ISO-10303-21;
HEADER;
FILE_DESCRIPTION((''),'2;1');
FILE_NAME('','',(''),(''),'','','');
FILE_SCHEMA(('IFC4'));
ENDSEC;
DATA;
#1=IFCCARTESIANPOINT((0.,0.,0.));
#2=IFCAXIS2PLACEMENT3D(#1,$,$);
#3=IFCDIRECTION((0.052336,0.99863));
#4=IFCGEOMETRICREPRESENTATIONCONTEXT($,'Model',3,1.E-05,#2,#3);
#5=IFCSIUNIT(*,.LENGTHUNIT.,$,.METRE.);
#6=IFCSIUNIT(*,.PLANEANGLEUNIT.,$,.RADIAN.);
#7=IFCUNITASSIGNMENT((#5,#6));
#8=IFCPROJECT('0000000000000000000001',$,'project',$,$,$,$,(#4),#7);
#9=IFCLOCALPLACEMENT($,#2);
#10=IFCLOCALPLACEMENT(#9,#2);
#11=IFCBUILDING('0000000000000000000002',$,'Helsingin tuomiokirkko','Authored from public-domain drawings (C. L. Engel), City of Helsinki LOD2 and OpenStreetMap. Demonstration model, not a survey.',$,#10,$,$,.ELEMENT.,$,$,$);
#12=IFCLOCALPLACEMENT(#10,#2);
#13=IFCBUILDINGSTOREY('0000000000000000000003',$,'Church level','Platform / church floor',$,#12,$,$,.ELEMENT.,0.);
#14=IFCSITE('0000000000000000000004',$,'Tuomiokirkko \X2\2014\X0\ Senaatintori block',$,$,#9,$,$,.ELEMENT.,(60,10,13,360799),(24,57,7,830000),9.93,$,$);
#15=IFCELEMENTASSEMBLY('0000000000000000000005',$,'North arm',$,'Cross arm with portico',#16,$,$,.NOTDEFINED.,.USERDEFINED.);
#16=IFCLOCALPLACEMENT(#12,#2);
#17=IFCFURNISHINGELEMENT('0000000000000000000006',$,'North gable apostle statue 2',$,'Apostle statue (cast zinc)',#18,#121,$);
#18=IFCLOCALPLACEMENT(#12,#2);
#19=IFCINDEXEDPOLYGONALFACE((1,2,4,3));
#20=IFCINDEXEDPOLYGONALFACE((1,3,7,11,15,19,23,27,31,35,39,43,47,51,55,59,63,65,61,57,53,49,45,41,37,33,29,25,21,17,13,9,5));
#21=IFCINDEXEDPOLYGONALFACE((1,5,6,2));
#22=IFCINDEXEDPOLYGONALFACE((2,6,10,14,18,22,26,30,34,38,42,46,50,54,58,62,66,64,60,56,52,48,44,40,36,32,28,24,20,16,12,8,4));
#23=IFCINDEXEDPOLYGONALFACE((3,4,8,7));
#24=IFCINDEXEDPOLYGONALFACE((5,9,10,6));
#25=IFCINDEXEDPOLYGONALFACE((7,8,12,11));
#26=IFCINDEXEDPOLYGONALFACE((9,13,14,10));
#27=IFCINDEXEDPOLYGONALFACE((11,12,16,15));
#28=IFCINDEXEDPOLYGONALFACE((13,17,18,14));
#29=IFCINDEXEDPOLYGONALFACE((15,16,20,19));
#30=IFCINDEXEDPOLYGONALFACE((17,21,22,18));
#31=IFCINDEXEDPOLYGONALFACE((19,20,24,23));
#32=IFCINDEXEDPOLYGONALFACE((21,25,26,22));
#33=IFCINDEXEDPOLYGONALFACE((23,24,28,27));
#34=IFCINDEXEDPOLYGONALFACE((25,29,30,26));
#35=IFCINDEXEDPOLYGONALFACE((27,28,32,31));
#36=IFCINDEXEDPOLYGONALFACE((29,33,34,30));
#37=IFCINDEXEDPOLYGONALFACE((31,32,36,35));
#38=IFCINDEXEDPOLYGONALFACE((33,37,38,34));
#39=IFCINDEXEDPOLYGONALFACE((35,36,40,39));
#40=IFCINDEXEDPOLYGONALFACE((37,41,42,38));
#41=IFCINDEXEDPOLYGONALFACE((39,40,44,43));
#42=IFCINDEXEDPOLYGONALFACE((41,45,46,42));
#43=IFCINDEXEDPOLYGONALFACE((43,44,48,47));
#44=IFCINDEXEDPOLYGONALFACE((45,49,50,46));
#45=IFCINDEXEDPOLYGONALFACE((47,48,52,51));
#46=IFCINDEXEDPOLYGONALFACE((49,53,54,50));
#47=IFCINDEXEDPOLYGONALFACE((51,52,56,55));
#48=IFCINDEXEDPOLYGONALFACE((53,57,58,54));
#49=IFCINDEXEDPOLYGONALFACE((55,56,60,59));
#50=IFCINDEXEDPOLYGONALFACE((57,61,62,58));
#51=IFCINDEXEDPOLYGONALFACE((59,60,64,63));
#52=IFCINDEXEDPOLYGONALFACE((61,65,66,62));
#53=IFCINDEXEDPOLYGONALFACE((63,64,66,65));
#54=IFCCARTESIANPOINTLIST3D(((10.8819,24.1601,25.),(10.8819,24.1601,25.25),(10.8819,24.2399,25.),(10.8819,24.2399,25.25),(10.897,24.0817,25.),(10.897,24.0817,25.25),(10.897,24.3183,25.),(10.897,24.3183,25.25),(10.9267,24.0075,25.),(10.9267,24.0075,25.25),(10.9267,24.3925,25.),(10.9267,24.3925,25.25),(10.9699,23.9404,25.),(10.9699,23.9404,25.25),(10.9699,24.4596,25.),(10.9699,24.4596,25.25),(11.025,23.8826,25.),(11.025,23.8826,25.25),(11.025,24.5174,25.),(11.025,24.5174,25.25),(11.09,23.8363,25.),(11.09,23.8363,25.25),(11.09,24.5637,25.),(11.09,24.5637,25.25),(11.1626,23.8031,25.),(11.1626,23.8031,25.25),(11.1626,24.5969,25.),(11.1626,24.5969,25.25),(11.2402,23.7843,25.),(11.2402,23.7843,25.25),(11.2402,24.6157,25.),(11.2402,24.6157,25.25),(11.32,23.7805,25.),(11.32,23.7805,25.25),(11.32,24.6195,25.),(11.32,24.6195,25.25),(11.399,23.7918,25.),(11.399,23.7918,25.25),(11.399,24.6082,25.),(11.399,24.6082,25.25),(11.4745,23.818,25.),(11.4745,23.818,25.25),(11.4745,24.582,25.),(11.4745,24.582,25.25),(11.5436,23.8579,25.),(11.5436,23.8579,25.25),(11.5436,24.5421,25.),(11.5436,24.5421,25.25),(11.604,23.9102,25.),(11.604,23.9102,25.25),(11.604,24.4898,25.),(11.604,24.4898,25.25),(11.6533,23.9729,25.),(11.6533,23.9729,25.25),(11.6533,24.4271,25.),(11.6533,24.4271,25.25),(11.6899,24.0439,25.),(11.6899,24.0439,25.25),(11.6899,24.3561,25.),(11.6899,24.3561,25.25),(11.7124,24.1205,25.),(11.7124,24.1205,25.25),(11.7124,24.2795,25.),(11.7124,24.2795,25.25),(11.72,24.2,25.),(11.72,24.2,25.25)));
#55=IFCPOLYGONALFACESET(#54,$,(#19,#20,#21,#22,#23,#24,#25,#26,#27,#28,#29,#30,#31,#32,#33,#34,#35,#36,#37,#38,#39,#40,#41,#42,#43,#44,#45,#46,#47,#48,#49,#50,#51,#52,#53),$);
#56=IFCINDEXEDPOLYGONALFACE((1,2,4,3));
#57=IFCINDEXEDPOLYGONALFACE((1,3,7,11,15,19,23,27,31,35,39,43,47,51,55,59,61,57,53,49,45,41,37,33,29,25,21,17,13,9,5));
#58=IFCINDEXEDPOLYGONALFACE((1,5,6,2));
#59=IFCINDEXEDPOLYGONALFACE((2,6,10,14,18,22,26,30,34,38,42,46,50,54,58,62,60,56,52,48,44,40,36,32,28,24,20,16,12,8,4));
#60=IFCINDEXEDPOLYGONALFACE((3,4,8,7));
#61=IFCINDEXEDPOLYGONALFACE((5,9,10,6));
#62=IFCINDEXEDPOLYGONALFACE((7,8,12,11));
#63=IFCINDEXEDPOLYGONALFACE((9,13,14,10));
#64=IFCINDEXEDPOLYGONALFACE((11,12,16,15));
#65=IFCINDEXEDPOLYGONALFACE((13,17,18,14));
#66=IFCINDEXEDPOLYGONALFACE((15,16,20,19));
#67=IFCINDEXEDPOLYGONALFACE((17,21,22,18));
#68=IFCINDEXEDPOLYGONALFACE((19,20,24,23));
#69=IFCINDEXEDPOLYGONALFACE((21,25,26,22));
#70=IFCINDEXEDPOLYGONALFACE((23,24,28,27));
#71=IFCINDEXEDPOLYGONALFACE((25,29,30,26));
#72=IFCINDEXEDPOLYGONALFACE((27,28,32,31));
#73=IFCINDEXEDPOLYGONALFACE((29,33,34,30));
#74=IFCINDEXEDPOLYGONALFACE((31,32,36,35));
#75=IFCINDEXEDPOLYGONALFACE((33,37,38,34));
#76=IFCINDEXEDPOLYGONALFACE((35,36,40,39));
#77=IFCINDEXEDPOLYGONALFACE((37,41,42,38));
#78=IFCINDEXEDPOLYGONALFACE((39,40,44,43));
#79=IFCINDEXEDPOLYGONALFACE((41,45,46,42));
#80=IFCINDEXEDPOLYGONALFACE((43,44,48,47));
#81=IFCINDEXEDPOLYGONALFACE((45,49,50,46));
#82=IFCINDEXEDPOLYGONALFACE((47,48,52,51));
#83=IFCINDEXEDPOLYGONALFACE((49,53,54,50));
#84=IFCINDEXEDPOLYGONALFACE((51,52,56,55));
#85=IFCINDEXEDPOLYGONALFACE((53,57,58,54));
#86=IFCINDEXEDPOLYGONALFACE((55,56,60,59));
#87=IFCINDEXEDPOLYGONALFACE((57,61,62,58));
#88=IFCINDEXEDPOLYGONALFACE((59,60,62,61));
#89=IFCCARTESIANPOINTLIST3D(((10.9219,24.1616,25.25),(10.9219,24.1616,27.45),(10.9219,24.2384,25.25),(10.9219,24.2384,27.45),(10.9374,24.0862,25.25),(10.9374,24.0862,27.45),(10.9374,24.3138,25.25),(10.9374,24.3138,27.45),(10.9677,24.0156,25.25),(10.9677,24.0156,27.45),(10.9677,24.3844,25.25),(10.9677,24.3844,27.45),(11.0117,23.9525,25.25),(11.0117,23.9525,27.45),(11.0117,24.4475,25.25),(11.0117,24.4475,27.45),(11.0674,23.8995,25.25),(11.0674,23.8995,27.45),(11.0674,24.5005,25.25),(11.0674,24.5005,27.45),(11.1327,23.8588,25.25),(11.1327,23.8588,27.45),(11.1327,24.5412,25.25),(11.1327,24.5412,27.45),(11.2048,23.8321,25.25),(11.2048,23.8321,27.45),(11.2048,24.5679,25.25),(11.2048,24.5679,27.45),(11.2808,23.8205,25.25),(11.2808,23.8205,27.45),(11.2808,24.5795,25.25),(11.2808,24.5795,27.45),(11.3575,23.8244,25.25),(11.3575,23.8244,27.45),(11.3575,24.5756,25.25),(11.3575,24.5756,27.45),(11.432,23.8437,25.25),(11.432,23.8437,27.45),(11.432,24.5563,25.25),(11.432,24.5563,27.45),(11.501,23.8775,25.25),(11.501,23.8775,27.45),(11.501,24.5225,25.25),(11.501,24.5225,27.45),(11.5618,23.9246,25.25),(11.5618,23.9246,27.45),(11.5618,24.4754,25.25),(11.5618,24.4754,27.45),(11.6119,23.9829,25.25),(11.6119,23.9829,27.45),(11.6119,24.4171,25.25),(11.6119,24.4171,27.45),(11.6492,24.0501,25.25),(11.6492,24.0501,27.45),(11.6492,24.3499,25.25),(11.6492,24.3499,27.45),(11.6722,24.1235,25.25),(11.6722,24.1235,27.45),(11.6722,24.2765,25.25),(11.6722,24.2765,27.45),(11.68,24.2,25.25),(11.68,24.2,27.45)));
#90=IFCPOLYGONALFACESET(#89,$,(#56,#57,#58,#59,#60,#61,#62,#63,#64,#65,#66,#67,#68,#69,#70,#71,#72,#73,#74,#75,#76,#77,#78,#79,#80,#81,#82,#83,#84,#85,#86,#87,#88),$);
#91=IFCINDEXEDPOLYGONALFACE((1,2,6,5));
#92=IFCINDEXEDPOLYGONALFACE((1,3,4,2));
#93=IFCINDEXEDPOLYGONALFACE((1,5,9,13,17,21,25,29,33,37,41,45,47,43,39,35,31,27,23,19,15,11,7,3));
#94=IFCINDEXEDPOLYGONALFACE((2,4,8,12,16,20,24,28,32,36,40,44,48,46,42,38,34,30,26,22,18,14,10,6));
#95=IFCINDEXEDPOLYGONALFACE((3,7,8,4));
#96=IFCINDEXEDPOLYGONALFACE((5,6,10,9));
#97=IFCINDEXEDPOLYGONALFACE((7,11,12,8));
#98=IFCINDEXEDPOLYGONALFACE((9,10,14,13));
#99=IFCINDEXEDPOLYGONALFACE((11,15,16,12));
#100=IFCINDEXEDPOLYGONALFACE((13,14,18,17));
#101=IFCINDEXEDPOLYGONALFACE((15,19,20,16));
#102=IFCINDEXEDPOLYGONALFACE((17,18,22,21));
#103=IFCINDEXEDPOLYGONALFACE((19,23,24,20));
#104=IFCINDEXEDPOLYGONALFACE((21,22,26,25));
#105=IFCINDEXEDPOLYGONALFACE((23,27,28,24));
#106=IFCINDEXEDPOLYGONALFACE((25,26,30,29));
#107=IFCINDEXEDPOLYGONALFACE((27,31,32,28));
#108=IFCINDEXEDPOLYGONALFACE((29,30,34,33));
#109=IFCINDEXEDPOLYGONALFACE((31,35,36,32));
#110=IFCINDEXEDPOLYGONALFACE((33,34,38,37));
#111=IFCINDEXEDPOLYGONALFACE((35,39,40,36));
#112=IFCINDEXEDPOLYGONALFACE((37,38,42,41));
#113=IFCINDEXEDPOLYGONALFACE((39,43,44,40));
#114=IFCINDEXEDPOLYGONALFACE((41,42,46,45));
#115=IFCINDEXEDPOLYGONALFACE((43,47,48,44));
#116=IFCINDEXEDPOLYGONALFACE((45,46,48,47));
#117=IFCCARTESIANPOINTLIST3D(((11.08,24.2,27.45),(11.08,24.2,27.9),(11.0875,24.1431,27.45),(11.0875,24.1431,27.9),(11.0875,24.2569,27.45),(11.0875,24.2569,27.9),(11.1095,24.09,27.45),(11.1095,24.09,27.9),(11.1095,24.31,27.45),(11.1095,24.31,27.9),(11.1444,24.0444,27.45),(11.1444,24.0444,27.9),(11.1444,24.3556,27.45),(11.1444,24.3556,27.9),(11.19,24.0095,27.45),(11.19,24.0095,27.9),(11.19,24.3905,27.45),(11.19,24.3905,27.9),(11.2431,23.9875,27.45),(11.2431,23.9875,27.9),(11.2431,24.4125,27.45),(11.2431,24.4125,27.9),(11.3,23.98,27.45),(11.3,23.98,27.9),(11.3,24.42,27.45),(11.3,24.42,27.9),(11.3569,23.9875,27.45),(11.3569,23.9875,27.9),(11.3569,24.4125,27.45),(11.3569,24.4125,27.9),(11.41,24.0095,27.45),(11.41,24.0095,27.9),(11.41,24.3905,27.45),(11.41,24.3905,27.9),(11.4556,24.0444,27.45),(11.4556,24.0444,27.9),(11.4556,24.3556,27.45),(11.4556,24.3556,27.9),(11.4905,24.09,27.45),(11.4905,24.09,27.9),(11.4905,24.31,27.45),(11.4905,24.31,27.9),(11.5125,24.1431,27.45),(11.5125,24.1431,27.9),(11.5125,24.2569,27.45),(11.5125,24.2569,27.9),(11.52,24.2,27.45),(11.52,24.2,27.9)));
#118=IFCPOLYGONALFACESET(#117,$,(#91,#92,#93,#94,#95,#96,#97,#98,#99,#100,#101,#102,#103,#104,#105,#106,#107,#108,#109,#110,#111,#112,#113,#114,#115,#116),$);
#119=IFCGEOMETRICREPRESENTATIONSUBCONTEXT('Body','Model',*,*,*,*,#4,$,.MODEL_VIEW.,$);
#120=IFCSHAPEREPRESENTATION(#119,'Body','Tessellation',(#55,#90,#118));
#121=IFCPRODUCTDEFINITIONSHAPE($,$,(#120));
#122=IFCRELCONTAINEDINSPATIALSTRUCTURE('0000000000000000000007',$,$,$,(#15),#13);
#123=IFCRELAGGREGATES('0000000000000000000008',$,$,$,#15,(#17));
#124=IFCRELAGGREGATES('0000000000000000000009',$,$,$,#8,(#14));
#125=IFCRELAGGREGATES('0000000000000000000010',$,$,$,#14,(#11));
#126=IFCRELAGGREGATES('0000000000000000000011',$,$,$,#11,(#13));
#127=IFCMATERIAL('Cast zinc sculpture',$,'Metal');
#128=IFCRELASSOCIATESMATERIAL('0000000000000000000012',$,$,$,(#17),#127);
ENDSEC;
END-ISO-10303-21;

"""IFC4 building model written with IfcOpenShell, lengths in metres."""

from ifc_helpers import new_model, si_unit, direction, frame, origin, origin_2d_with_axis, place, context, subcontext, project, spatial, circle, extrude, material, element, aggregate, save


model = new_model("IFC4")

# Units and contexts
model_context = context("Model", 3, precision=1e-05, world=origin(), true_north=direction((0.052336, 0.99863)))
body_context = subcontext(model_context, "Body", "Model", "MODEL_VIEW")
ifc_project = project(units=[si_unit("LENGTHUNIT", "METRE"), si_unit("PLANEANGLEUNIT", "RADIAN")], contexts=[model_context])

# Site, building, storey
site_placement = place(None, origin())
site = spatial("IfcSite", under=ifc_project, at=site_placement, Name="Tuomiokirkko — Senaatintori block", CompositionType="ELEMENT", RefLatitude=(60, 10, 13, 360799), RefLongitude=(24, 57, 7, 830000), RefElevation=9.93)
building_placement = place(site_placement, origin())
building = spatial("IfcBuilding", under=site, at=building_placement, Name="Helsingin tuomiokirkko", Description="Authored from public-domain drawings (C. L. Engel), City of Helsinki LOD2 and OpenStreetMap. Demonstration model, not a survey.", CompositionType="ELEMENT")
storey_placement = place(building_placement, origin())
storey = spatial("IfcBuildingStorey", under=building, at=storey_placement, Name="Church level", Description="Platform / church floor", CompositionType="ELEMENT", Elevation=0.0)

# Element assembly
assembly_1_placement = place(building_placement, origin())
assembly_1 = element("IfcElementAssembly", 1, at=assembly_1_placement, inside=storey, Name="North arm", ObjectType="Cross arm with portico", AssemblyPlace="NOTDEFINED", PredefinedType="USERDEFINED")

# Furnishing element
ifc_material_1 = material(Name="Cast zinc sculpture", Category="Metal")
furnishing_1_placement = place(building_placement, origin())
furnishing_1 = element("IfcFurnishingElement", 2, at=furnishing_1_placement, material=ifc_material_1, Name="North gable apostle statue 2", ObjectType="Apostle statue (cast zinc)", context=body_context, shape_type="SweptSolid", body=[
    extrude(circle(Radius=0.42, at=origin_2d_with_axis()), frame((11.3, 24.2, 25.0)), (0.0, 0.0, 1.0), 0.25),
    extrude(circle(Radius=0.38, at=origin_2d_with_axis()), frame((11.3, 24.2, 25.25)), (0.0, 0.0, 1.0), 2.2),
    extrude(circle(Radius=0.22, at=origin_2d_with_axis()), frame((11.3, 24.2, 27.45)), (0.0, 0.0, 1.0), 0.45),
])
aggregate(assembly_1, [furnishing_1])

save(model, "model.ifc")
